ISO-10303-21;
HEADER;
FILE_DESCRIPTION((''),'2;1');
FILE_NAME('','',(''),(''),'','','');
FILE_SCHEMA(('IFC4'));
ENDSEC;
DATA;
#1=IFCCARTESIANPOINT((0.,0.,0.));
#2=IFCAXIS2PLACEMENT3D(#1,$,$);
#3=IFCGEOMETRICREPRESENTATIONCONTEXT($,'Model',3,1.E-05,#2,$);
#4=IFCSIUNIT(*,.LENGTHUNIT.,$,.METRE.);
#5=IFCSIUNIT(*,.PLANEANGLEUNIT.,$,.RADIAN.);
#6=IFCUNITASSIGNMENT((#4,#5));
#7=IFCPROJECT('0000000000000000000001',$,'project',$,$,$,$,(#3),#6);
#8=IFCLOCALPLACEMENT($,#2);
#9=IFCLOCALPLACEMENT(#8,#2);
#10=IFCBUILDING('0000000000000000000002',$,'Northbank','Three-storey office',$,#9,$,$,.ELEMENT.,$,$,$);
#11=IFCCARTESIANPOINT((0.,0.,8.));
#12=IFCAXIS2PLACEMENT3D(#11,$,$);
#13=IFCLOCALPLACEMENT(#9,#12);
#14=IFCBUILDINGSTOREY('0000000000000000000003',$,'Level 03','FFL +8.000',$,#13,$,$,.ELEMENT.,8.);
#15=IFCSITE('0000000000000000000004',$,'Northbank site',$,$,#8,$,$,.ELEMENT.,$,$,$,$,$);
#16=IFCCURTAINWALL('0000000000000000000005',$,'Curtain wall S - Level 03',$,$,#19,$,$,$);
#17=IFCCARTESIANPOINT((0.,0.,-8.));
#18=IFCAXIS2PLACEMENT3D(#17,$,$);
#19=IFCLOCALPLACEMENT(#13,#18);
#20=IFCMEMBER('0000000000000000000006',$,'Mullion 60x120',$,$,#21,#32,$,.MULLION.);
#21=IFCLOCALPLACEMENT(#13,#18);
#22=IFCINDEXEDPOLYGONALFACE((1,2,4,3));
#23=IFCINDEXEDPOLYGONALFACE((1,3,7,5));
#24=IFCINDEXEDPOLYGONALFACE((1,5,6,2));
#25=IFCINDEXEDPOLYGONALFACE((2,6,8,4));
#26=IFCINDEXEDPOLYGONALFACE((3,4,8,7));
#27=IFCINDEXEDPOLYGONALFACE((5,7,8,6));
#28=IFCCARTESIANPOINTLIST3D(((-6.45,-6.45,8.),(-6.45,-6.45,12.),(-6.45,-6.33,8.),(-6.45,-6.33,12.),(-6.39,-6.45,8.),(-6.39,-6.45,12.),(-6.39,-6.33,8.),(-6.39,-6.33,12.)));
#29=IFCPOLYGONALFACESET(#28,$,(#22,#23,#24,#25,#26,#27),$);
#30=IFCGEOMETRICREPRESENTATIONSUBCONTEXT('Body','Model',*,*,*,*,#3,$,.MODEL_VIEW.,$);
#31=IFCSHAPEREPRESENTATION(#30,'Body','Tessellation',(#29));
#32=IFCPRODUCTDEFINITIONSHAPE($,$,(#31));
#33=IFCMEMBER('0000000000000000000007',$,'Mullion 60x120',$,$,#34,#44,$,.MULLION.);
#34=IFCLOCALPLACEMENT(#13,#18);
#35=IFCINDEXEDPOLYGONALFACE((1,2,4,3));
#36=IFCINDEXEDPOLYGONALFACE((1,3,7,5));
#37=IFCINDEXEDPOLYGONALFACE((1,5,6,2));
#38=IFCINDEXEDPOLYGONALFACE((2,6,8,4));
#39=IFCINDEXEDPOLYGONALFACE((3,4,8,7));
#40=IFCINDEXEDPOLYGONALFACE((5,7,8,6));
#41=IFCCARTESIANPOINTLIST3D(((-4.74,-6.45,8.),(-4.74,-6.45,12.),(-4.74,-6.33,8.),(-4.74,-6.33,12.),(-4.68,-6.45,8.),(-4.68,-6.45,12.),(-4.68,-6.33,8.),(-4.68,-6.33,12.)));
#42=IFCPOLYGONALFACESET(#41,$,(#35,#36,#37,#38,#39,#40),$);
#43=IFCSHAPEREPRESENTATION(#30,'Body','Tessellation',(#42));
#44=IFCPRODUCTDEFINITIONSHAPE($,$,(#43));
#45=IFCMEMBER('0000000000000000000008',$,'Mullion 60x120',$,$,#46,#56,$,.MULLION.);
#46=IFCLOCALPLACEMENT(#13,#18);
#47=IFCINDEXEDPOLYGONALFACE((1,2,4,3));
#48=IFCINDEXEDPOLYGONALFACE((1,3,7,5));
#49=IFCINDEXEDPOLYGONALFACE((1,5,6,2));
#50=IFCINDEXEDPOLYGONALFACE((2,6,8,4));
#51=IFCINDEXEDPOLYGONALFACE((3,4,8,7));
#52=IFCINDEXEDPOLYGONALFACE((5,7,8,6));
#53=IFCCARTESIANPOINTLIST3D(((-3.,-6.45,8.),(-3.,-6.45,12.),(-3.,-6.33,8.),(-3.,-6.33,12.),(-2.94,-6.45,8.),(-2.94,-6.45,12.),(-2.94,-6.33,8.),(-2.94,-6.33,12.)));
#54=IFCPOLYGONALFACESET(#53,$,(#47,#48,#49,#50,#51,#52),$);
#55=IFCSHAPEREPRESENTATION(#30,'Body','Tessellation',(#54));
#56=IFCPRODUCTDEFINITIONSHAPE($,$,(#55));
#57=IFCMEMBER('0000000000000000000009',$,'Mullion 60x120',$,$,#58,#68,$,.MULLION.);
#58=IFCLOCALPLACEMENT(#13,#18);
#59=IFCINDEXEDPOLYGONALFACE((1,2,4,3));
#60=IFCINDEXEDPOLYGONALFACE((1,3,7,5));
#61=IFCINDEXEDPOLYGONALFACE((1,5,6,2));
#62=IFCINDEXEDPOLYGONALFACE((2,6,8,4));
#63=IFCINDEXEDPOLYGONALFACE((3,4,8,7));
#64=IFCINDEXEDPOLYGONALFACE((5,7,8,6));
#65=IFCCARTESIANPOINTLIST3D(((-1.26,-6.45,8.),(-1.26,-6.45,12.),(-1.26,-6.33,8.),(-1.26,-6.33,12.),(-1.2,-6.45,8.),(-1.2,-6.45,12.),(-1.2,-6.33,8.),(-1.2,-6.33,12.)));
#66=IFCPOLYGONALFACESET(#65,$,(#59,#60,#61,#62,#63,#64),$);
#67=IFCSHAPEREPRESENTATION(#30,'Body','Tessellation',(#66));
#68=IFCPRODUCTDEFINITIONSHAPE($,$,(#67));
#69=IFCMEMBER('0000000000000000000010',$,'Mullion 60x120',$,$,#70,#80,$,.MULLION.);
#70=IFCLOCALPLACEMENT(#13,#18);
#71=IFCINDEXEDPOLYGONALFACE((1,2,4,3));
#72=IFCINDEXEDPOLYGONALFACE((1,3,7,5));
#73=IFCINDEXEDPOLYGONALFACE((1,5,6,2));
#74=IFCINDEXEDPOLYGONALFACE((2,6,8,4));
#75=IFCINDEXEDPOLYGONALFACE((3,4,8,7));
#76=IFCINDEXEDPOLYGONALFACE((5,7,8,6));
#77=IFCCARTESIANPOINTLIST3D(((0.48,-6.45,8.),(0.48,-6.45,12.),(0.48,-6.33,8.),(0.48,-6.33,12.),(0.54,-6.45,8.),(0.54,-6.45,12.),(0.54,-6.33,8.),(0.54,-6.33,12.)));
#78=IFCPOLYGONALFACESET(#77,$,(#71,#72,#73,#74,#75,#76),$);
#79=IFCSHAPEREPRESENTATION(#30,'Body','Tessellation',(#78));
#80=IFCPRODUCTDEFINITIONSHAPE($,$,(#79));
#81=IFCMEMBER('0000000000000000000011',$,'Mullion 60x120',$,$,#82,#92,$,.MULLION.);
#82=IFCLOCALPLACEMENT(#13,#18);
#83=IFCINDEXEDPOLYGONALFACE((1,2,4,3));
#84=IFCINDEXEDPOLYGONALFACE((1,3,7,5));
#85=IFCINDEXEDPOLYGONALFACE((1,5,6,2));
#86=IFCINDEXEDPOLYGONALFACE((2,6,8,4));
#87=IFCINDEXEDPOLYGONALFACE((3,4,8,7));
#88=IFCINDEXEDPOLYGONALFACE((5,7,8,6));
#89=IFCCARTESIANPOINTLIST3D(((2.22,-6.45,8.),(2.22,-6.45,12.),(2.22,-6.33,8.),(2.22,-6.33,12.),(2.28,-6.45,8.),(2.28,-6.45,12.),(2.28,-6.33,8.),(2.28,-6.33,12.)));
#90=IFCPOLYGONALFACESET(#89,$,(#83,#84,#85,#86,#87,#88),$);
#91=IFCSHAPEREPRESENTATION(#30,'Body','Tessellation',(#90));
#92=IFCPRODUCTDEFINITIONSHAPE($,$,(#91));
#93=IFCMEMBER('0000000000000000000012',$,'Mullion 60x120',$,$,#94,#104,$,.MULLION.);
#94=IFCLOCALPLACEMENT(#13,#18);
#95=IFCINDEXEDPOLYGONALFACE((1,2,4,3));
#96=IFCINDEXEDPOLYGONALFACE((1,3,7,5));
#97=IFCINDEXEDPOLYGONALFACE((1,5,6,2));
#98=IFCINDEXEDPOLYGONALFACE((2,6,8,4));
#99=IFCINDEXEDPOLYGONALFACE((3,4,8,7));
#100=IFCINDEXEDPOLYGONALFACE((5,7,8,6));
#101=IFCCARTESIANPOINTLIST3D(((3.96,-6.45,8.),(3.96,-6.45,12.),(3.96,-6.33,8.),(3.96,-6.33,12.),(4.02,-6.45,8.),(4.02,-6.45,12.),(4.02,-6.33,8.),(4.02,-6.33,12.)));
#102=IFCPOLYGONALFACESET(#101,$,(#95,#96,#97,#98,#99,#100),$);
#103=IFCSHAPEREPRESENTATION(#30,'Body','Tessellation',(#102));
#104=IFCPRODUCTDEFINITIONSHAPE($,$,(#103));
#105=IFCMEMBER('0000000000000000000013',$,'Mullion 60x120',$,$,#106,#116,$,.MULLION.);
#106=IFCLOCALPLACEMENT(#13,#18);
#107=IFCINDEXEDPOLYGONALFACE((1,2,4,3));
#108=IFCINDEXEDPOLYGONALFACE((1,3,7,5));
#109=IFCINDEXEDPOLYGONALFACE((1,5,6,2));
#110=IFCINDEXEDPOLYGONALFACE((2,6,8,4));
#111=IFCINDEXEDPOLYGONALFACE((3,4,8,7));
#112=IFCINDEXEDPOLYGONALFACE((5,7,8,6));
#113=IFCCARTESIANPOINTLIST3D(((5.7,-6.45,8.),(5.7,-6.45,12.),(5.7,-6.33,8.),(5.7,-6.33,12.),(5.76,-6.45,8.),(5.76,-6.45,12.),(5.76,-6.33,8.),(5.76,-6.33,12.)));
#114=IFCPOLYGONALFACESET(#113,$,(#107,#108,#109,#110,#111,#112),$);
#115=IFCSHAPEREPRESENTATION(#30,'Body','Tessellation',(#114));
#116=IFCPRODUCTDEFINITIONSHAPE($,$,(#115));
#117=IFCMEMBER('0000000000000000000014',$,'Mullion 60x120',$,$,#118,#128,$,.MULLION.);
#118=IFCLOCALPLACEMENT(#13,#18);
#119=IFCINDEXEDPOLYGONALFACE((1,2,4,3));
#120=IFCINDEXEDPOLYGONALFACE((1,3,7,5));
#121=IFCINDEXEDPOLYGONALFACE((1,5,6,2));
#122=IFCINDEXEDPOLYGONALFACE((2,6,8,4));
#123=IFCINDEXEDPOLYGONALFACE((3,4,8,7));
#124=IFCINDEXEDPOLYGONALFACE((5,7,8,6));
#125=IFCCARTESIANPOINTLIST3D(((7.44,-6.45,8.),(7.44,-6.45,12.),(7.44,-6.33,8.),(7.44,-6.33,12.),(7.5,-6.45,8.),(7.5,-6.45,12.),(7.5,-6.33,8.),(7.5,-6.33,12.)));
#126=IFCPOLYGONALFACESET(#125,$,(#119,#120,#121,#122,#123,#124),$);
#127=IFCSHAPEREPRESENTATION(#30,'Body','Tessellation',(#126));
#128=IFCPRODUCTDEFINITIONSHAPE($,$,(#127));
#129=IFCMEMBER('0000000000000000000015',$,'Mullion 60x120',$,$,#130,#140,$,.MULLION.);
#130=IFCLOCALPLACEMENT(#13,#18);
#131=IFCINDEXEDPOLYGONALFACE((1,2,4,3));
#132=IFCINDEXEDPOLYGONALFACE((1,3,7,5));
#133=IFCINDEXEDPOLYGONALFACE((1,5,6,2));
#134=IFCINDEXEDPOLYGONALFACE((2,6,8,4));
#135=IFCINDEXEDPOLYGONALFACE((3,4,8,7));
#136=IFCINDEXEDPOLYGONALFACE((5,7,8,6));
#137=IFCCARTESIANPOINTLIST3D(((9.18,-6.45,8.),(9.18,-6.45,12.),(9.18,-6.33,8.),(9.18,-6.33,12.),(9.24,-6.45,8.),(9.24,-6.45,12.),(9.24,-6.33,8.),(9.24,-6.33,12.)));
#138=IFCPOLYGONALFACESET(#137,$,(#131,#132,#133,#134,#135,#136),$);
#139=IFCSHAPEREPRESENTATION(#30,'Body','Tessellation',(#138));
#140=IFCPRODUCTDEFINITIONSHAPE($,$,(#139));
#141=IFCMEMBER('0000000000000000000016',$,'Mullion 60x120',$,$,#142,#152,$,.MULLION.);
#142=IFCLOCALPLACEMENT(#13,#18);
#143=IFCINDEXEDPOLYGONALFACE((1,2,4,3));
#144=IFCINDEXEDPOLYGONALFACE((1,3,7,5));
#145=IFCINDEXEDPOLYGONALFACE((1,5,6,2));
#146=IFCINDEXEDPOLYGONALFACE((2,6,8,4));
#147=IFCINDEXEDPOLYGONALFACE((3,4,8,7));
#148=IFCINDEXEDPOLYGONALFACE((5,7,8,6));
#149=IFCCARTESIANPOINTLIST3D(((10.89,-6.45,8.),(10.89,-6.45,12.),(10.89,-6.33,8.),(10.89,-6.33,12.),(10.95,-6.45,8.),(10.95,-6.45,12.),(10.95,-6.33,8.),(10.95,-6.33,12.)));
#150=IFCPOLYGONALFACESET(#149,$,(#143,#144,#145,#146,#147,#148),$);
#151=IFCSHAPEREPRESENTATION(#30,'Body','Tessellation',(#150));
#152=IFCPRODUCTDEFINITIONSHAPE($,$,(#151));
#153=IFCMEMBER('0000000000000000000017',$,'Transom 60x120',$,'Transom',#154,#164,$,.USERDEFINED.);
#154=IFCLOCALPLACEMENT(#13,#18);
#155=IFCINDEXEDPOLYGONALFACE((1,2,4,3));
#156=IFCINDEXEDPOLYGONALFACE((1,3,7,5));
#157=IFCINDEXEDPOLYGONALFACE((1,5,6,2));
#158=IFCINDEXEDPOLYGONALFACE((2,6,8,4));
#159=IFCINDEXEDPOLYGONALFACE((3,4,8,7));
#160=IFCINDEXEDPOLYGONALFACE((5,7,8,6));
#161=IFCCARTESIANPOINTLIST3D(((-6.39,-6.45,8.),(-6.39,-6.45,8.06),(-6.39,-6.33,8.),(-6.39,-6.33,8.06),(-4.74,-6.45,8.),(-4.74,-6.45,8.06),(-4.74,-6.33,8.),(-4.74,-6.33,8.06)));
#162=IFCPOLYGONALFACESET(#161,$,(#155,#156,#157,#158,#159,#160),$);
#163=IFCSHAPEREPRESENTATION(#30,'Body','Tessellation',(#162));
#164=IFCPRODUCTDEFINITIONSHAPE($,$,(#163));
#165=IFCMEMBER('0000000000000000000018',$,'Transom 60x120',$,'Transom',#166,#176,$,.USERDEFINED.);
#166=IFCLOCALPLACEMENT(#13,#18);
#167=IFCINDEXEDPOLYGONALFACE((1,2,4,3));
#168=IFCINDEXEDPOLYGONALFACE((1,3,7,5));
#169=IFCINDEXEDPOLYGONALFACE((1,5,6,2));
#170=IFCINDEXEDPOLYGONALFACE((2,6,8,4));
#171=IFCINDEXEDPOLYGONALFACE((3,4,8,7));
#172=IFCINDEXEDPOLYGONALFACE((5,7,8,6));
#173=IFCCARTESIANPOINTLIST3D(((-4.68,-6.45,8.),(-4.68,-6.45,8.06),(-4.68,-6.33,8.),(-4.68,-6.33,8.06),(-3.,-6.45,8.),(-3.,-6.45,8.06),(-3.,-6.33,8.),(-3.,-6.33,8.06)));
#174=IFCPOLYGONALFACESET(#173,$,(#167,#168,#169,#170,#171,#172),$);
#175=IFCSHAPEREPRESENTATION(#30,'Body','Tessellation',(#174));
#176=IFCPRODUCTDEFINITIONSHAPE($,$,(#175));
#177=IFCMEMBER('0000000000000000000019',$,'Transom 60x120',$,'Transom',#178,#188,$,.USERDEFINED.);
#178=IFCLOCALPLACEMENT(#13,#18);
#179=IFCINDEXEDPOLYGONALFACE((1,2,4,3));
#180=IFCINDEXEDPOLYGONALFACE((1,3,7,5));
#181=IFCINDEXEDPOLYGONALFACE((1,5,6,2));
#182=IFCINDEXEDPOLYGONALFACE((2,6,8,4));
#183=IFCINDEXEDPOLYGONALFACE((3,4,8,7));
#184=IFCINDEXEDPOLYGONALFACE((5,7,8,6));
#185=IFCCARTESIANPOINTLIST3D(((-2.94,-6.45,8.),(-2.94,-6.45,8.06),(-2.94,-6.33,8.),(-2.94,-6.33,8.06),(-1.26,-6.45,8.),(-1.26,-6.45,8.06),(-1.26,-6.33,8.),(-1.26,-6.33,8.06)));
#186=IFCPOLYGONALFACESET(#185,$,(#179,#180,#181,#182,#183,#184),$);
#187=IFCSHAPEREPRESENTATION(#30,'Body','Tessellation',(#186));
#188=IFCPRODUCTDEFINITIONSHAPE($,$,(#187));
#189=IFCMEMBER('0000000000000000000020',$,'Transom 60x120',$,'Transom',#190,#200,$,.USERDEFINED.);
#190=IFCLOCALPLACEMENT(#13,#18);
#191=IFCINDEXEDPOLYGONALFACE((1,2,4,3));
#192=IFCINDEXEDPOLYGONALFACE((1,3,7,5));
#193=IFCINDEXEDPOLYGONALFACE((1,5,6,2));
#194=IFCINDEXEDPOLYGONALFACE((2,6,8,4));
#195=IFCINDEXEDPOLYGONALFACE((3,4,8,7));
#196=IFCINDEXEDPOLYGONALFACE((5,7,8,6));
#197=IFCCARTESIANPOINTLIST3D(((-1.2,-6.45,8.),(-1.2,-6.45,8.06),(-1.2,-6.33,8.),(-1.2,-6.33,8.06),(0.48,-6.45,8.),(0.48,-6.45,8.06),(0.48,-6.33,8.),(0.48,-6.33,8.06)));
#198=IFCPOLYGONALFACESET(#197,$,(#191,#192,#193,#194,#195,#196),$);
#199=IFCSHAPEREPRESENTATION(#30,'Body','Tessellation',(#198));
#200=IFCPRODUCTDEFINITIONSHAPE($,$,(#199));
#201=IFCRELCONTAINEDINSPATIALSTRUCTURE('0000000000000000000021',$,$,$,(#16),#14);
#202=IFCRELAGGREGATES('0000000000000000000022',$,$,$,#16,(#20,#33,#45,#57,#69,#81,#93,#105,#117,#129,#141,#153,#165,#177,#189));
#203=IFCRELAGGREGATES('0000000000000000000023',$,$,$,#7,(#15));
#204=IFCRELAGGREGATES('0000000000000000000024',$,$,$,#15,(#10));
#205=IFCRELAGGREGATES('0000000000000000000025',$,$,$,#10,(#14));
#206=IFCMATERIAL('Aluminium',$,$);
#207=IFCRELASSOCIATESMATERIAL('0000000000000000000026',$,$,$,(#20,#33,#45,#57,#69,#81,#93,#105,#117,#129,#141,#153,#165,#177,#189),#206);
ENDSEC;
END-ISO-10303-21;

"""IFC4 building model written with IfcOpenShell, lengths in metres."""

from ifc_helpers import new_model, si_unit, frame, origin, place, context, subcontext, project, spatial, rectangle, extrude, material, element, aggregate, save


model = new_model("IFC4")

# Units and contexts
model_context = context("Model", 3, precision=1e-05, world=origin())
body_context = subcontext(model_context, "Body", "Model", "MODEL_VIEW")
ifc_project = project(units=[si_unit("LENGTHUNIT", "METRE"), si_unit("PLANEANGLEUNIT", "RADIAN")], contexts=[model_context])

# Site, building, storey
site_placement = place(None, origin())
site = spatial("IfcSite", under=ifc_project, at=site_placement, Name="Northbank site", CompositionType="ELEMENT")
building_placement = place(site_placement, origin())
building = spatial("IfcBuilding", under=site, at=building_placement, Name="Northbank", Description="Three-storey office", CompositionType="ELEMENT")
storey_placement = place(building_placement, frame((0.0, 0.0, 8.0)))
storey = spatial("IfcBuildingStorey", under=building, at=storey_placement, Name="Level 03", Description="FFL +8.000", CompositionType="ELEMENT", Elevation=8.0)

# Curtain wall, members
curtain_wall_placement = place(storey_placement, frame((0.0, 0.0, -8.0)))
curtain_wall = element("IfcCurtainWall", 1, at=curtain_wall_placement, inside=storey, Name="Curtain wall S - Level 03")
ifc_material = material(Name="Aluminium")
member_1_placement = place(storey_placement, frame((0.0, 0.0, -8.0)))
member_1 = element("IfcMember", 2, at=member_1_placement, material=ifc_material, Name="Mullion 60x120", PredefinedType="MULLION", context=body_context, shape_type="SweptSolid", body=[
    extrude(rectangle(XDim=0.06, YDim=0.12), frame((-6.42, -6.39, 8.0)), (0.0, 0.0, 1.0), 4.0),
])
member_2_placement = place(storey_placement, frame((0.0, 0.0, -8.0)))
member_2 = element("IfcMember", 3, at=member_2_placement, material=ifc_material, Name="Mullion 60x120", PredefinedType="MULLION", context=body_context, shape_type="SweptSolid", body=[
    extrude(rectangle(XDim=0.06, YDim=0.12), frame((-4.71, -6.39, 8.0)), (0.0, 0.0, 1.0), 4.0),
])
member_3_placement = place(storey_placement, frame((0.0, 0.0, -8.0)))
member_3 = element("IfcMember", 4, at=member_3_placement, material=ifc_material, Name="Mullion 60x120", PredefinedType="MULLION", context=body_context, shape_type="SweptSolid", body=[
    extrude(rectangle(XDim=0.06, YDim=0.12), frame((-2.97, -6.39, 8.0)), (0.0, 0.0, 1.0), 4.0),
])
member_4_placement = place(storey_placement, frame((0.0, 0.0, -8.0)))
member_4 = element("IfcMember", 5, at=member_4_placement, material=ifc_material, Name="Mullion 60x120", PredefinedType="MULLION", context=body_context, shape_type="SweptSolid", body=[
    extrude(rectangle(XDim=0.06, YDim=0.12), frame((-1.23, -6.39, 8.0)), (0.0, 0.0, 1.0), 4.0),
])
member_5_placement = place(storey_placement, frame((0.0, 0.0, -8.0)))
member_5 = element("IfcMember", 6, at=member_5_placement, material=ifc_material, Name="Mullion 60x120", PredefinedType="MULLION", context=body_context, shape_type="SweptSolid", body=[
    extrude(rectangle(XDim=0.06, YDim=0.12), frame((0.51, -6.39, 8.0)), (0.0, 0.0, 1.0), 4.0),
])
member_6_placement = place(storey_placement, frame((0.0, 0.0, -8.0)))
member_6 = element("IfcMember", 7, at=member_6_placement, material=ifc_material, Name="Mullion 60x120", PredefinedType="MULLION", context=body_context, shape_type="SweptSolid", body=[
    extrude(rectangle(XDim=0.06, YDim=0.12), frame((2.25, -6.39, 8.0)), (0.0, 0.0, 1.0), 4.0),
])
member_7_placement = place(storey_placement, frame((0.0, 0.0, -8.0)))
member_7 = element("IfcMember", 8, at=member_7_placement, material=ifc_material, Name="Mullion 60x120", PredefinedType="MULLION", context=body_context, shape_type="SweptSolid", body=[
    extrude(rectangle(XDim=0.06, YDim=0.12), frame((3.99, -6.39, 8.0)), (0.0, 0.0, 1.0), 4.0),
])
member_8_placement = place(storey_placement, frame((0.0, 0.0, -8.0)))
member_8 = element("IfcMember", 9, at=member_8_placement, material=ifc_material, Name="Mullion 60x120", PredefinedType="MULLION", context=body_context, shape_type="SweptSolid", body=[
    extrude(rectangle(XDim=0.06, YDim=0.12), frame((5.73, -6.39, 8.0)), (0.0, 0.0, 1.0), 4.0),
])
member_9_placement = place(storey_placement, frame((0.0, 0.0, -8.0)))
member_9 = element("IfcMember", 10, at=member_9_placement, material=ifc_material, Name="Mullion 60x120", PredefinedType="MULLION", context=body_context, shape_type="SweptSolid", body=[
    extrude(rectangle(XDim=0.06, YDim=0.12), frame((7.47, -6.39, 8.0)), (0.0, 0.0, 1.0), 4.0),
])
member_10_placement = place(storey_placement, frame((0.0, 0.0, -8.0)))
member_10 = element("IfcMember", 11, at=member_10_placement, material=ifc_material, Name="Mullion 60x120", PredefinedType="MULLION", context=body_context, shape_type="SweptSolid", body=[
    extrude(rectangle(XDim=0.06, YDim=0.12), frame((9.21, -6.39, 8.0)), (0.0, 0.0, 1.0), 4.0),
])
member_11_placement = place(storey_placement, frame((0.0, 0.0, -8.0)))
member_11 = element("IfcMember", 12, at=member_11_placement, material=ifc_material, Name="Mullion 60x120", PredefinedType="MULLION", context=body_context, shape_type="SweptSolid", body=[
    extrude(rectangle(XDim=0.06, YDim=0.12), frame((10.92, -6.39, 8.0)), (0.0, 0.0, 1.0), 4.0),
])
member_12_placement = place(storey_placement, frame((0.0, 0.0, -8.0)))
member_12 = element("IfcMember", 13, at=member_12_placement, material=ifc_material, Name="Transom 60x120", ObjectType="Transom", PredefinedType="USERDEFINED", context=body_context, shape_type="SweptSolid", body=[
    extrude(rectangle(XDim=1.65, YDim=0.12), frame((-5.565, -6.39, 8.0)), (0.0, 0.0, 1.0), 0.06),
])
member_13_placement = place(storey_placement, frame((0.0, 0.0, -8.0)))
member_13 = element("IfcMember", 14, at=member_13_placement, material=ifc_material, Name="Transom 60x120", ObjectType="Transom", PredefinedType="USERDEFINED", context=body_context, shape_type="SweptSolid", body=[
    extrude(rectangle(XDim=1.68, YDim=0.12), frame((-3.84, -6.39, 8.0)), (0.0, 0.0, 1.0), 0.06),
])
member_14_placement = place(storey_placement, frame((0.0, 0.0, -8.0)))
member_14 = element("IfcMember", 15, at=member_14_placement, material=ifc_material, Name="Transom 60x120", ObjectType="Transom", PredefinedType="USERDEFINED", context=body_context, shape_type="SweptSolid", body=[
    extrude(rectangle(XDim=1.68, YDim=0.12), frame((-2.1, -6.39, 8.0)), (0.0, 0.0, 1.0), 0.06),
])
member_15_placement = place(storey_placement, frame((0.0, 0.0, -8.0)))
member_15 = element("IfcMember", 16, at=member_15_placement, material=ifc_material, Name="Transom 60x120", ObjectType="Transom", PredefinedType="USERDEFINED", context=body_context, shape_type="SweptSolid", body=[
    extrude(rectangle(XDim=1.68, YDim=0.12), frame((-0.36, -6.39, 8.0)), (0.0, 0.0, 1.0), 0.06),
])
aggregate(curtain_wall, [member_1, member_2, member_3, member_4, member_5, member_6, member_7, member_8, member_9, member_10, member_11, member_12, member_13, member_14, member_15])

save(model, "model.ifc")
